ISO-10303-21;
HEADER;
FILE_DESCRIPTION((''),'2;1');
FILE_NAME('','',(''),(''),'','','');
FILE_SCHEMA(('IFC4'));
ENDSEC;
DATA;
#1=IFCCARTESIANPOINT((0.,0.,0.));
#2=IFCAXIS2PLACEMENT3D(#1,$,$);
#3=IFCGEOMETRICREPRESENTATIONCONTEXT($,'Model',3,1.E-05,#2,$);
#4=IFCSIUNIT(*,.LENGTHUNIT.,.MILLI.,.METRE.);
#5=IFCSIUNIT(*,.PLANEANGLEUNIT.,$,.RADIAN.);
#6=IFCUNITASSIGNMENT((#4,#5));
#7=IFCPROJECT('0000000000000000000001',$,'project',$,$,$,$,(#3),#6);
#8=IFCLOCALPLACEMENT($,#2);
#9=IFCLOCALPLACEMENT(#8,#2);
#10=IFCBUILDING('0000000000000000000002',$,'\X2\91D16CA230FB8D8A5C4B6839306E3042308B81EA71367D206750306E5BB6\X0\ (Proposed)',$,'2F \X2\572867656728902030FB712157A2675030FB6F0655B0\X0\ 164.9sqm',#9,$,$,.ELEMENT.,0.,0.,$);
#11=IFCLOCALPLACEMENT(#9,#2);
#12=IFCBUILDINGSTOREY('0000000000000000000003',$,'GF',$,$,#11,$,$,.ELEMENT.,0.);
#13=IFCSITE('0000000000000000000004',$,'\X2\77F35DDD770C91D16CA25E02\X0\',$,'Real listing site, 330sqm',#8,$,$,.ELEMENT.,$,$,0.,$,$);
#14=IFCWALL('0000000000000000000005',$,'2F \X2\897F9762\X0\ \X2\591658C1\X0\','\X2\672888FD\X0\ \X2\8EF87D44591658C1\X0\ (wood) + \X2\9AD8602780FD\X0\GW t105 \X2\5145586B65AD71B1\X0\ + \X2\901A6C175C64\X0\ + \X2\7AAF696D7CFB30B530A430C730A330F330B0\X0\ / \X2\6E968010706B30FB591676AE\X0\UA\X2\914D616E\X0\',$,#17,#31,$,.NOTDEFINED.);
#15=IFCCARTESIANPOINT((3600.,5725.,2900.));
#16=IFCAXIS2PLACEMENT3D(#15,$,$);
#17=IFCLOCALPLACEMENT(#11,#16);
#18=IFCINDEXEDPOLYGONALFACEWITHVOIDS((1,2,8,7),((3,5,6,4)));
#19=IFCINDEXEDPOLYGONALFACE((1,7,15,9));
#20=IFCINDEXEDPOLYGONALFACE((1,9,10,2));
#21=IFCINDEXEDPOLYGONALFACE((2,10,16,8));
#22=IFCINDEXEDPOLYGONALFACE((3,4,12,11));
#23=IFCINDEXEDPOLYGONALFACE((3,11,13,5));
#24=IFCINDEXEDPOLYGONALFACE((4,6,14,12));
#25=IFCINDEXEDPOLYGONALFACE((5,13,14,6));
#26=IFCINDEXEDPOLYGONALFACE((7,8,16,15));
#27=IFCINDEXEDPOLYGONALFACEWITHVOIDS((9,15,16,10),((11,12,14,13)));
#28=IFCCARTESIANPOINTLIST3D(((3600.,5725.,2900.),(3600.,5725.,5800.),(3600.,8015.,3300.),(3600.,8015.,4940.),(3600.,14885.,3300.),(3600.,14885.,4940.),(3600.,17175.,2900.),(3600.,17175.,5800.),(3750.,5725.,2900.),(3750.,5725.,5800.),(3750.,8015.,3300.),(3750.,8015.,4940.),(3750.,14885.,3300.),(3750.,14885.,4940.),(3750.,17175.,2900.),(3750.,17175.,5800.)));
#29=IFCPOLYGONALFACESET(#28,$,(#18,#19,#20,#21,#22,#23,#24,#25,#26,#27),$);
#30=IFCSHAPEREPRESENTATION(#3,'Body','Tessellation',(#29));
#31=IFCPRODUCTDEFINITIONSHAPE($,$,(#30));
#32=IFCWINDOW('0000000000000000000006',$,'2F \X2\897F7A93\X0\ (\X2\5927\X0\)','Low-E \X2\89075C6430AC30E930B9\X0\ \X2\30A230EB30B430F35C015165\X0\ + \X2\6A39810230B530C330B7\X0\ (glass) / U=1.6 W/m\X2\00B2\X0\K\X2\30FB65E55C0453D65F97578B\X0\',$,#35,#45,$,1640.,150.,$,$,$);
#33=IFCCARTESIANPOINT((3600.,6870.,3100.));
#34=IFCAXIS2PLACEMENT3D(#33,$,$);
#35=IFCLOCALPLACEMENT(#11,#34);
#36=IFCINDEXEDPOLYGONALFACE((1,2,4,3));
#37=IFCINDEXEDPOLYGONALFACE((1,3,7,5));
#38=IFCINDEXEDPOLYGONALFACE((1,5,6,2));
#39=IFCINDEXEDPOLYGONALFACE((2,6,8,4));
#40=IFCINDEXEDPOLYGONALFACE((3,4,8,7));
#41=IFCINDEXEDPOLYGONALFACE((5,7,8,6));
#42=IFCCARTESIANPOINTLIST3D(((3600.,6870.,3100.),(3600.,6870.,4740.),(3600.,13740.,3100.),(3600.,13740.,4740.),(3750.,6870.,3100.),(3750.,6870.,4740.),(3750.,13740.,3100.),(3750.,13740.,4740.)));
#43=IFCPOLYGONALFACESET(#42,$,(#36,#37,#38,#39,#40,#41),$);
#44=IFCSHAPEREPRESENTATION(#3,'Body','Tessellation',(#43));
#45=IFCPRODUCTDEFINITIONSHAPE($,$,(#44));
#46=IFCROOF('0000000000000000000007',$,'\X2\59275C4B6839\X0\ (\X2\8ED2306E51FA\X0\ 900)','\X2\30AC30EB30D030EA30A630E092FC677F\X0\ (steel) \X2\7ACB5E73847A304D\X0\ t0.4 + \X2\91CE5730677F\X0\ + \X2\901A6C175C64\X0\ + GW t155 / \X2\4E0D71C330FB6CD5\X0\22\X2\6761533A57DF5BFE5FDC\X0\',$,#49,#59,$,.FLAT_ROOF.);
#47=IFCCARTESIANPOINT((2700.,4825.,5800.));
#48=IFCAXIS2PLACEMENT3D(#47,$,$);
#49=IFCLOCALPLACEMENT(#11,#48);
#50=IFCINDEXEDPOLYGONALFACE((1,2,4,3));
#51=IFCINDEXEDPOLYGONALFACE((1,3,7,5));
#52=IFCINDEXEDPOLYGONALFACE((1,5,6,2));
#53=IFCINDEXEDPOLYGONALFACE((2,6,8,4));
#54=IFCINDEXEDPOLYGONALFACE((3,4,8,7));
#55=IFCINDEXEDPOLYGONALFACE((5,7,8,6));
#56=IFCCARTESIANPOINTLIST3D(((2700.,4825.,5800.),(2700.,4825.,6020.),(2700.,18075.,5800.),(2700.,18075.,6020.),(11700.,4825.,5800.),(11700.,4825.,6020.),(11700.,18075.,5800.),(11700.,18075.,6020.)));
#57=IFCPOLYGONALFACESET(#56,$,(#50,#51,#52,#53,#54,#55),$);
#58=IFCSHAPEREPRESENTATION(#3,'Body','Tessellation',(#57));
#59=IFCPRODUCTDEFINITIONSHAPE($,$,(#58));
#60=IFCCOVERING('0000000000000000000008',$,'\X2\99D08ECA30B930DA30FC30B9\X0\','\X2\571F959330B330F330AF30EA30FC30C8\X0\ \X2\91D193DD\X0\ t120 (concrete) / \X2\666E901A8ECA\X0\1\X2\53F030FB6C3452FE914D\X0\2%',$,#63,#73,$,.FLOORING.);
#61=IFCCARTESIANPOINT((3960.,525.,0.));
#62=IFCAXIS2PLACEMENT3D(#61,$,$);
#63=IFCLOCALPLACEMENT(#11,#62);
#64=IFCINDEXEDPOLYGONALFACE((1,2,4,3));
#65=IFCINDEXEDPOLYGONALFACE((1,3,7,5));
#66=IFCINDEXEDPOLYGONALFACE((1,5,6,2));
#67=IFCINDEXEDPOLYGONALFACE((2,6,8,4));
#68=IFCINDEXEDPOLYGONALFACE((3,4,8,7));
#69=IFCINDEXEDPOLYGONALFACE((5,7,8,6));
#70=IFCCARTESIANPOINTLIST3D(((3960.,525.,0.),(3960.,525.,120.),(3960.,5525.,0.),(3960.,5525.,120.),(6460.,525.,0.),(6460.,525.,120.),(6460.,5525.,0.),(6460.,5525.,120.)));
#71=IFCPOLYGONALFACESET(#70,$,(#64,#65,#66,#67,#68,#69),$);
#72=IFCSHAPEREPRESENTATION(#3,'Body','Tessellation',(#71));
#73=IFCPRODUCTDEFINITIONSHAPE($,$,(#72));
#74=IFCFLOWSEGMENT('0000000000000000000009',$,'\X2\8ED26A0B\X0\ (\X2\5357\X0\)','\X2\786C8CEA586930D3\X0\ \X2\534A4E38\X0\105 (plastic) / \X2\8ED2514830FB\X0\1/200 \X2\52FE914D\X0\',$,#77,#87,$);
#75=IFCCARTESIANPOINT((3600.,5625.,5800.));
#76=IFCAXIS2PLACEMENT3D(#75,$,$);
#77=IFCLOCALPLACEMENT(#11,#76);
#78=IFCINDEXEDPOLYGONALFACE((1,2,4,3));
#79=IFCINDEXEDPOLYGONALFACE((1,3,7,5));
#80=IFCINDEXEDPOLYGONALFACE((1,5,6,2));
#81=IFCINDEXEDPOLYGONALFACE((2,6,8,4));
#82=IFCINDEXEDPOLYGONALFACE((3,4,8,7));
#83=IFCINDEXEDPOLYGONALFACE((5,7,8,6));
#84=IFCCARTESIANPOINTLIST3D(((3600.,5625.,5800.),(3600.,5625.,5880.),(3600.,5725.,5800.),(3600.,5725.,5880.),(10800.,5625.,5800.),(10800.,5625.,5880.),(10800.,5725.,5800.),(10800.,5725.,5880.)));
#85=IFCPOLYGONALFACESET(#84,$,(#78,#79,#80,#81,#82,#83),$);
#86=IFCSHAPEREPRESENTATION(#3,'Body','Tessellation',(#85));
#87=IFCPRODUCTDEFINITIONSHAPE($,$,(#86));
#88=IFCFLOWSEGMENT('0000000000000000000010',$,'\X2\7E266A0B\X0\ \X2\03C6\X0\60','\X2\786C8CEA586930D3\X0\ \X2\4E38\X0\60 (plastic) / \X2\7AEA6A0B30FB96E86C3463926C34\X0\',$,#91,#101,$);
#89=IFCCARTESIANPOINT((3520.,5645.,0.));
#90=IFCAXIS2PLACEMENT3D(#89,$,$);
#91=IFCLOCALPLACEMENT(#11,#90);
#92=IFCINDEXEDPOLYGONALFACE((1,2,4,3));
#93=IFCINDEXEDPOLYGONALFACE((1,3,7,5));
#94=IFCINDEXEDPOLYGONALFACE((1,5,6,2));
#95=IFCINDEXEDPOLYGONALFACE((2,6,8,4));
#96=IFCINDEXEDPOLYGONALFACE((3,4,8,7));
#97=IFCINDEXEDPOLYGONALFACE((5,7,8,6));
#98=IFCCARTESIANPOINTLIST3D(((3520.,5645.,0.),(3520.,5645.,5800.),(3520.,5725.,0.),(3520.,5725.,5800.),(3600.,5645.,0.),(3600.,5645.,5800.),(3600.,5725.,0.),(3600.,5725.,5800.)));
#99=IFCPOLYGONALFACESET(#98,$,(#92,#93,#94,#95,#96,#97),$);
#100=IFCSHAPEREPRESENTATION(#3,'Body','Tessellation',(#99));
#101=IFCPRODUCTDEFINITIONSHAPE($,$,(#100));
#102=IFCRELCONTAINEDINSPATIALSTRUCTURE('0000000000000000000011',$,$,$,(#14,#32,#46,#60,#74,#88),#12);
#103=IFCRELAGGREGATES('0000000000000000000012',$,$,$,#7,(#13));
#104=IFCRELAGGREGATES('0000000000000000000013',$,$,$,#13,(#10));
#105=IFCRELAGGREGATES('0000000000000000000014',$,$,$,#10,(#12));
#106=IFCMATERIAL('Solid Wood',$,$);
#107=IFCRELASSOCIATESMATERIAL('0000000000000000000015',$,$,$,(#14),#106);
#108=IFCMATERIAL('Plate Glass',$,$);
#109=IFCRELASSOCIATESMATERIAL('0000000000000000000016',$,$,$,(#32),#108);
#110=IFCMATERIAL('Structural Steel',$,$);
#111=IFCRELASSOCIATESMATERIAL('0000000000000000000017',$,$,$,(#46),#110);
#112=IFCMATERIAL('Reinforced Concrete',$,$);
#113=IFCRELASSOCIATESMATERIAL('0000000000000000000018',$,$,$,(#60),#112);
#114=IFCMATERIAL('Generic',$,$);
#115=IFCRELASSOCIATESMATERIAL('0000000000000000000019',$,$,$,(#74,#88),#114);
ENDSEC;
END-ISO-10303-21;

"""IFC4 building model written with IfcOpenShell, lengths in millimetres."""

from ifc_helpers import new_model, si_unit, frame, frame_2d, origin, place, context, project, spatial, rectangle, extrude, material, element, fill, save


model = new_model("IFC4")

# Units and contexts
model_context = context("Model", 3, precision=1e-05, world=origin())
ifc_project = project(units=[si_unit("LENGTHUNIT", "METRE", prefix="MILLI"), si_unit("PLANEANGLEUNIT", "RADIAN")], contexts=[model_context])

# Site, building, storey
site_placement = place(None, origin())
site = spatial("IfcSite", under=ifc_project, at=site_placement, Name="石川県金沢市", ObjectType="Real listing site, 330sqm", CompositionType="ELEMENT", RefElevation=0.0)
building_placement = place(site_placement, origin())
building = spatial("IfcBuilding", under=site, at=building_placement, Name="金沢・越屋根のある自然素材の家 (Proposed)", ObjectType="2F 在来木造・無垢材・漆喰 164.9sqm", CompositionType="ELEMENT", ElevationOfRefHeight=0.0, ElevationOfTerrain=0.0)
storey_placement = place(building_placement, origin())
storey = spatial("IfcBuildingStorey", under=building, at=storey_placement, Name="GF", CompositionType="ELEMENT", Elevation=0.0)

# Shared definitions
ifc_material_1 = material(Name="Solid Wood")

# Shared definitions
ifc_material_2 = material(Name="Reinforced Concrete")

# Shared definitions
ifc_material_3 = material(Name="Plate Glass")

# Wall, opening, window
wall_1_placement = place(storey_placement, frame((3600.0, 5725.0, 2900.0)))
wall_1 = element("IfcWall", 1, at=wall_1_placement, inside=storey, material=ifc_material_1, Name="2F 西面 外壁", Description="木製 軸組外壁 (wood) + 高性能GW t105 充填断熱 + 通気層 + 窯業系サイディング / 準耐火・外皮UA配慮", PredefinedType="NOTDEFINED", context=model_context, shape_type="SweptSolid", body=[
    extrude(rectangle(XDim=150.0, YDim=11450.0, at=frame_2d((75.0, 5725.0))), frame((3600.0, 5725.0, 2900.0)), (0.0, 0.0, 1.0), 2900.0),
])
opening_1_placement = place(storey_placement, frame((3600.0, 6870.0, 3100.0)))
opening_1 = element("IfcOpeningElement", 2, at=opening_1_placement, cuts=wall_1, PredefinedType="NOTDEFINED", context=model_context, shape_type="SweptSolid", body=[
    extrude(rectangle(XDim=150.0, YDim=6870.0, at=frame_2d((75.0, 3435.0))), frame((3600.0, 6870.0, 3100.0)), (0.0, 0.0, 1.0), 1640.0),
])
window_1_placement = place(storey_placement, frame((3600.0, 6870.0, 3100.0)))
window_1 = element("IfcWindow", 3, at=window_1_placement, inside=storey, material=ifc_material_3, Name="2F 西窓 (大)", Description="Low-E 複層ガラス アルゴン封入 + 樹脂サッシ (glass) / U=1.6 W/m²K・日射取得型", OverallHeight=1640.0, OverallWidth=150.0, context=model_context, shape_type="SweptSolid", body=[
    extrude(rectangle(XDim=150.0, YDim=6870.0, at=frame_2d((75.0, 3435.0))), frame((3600.0, 6870.0, 3100.0)), (0.0, 0.0, 1.0), 1640.0),
])
fill(opening_1, window_1)

# Roof
ifc_material_4 = material(Name="Structural Steel")
roof_placement = place(storey_placement, frame((2700.0, 4825.0, 5800.0)))
element("IfcRoof", 4, at=roof_placement, inside=storey, material=ifc_material_4, Name="大屋根 (軒の出 900)", Description="ガルバリウム鋼板 (steel) 立平葺き t0.4 + 野地板 + 通気層 + GW t155 / 不燃・法22条区域対応", PredefinedType="FLAT_ROOF", context=model_context, shape_type="SweptSolid", body=[
    extrude(rectangle(XDim=9000.0, YDim=13250.0, at=frame_2d((4500.0, 6625.0))), frame((2700.0, 4825.0, 5800.0)), (0.0, 0.0, 1.0), 220.0),
])

# Covering
covering_placement = place(storey_placement, frame((3960.0, 525.0, 0.0)))
element("IfcCovering", 5, at=covering_placement, inside=storey, material=ifc_material_2, Name="駐車スペース", Description="土間コンクリート 金鏝 t120 (concrete) / 普通車1台・水勾配2%", PredefinedType="FLOORING", context=model_context, shape_type="SweptSolid", body=[
    extrude(rectangle(XDim=2500.0, YDim=5000.0, at=frame_2d((1250.0, 2500.0))), frame((3960.0, 525.0, 0.0)), (0.0, 0.0, 1.0), 120.0),
])

# Flow segments
ifc_material_5 = material(Name="Generic")
flow_segment_1_placement = place(storey_placement, frame((3600.0, 5625.0, 5800.0)))
element("IfcFlowSegment", 6, at=flow_segment_1_placement, inside=storey, material=ifc_material_5, Name="軒樋 (南)", Description="硬質塩ビ 半丸105 (plastic) / 軒先・1/200 勾配", context=model_context, shape_type="SweptSolid", body=[
    extrude(rectangle(XDim=7200.0, YDim=100.0, at=frame_2d((3600.0, 50.0))), frame((3600.0, 5625.0, 5800.0)), (0.0, 0.0, 1.0), 80.0),
])
flow_segment_2_placement = place(storey_placement, frame((3520.0, 5645.0, 0.0)))
element("IfcFlowSegment", 7, at=flow_segment_2_placement, inside=storey, material=ifc_material_5, Name="縦樋 φ60", Description="硬質塩ビ 丸60 (plastic) / 竪樋・雨水排水", context=model_context, shape_type="SweptSolid", body=[
    extrude(rectangle(XDim=80.0, YDim=80.0, at=frame_2d((40.0, 40.0))), frame((3520.0, 5645.0, 0.0)), (0.0, 0.0, 1.0), 5800.0),
])

save(model, "model.ifc")
